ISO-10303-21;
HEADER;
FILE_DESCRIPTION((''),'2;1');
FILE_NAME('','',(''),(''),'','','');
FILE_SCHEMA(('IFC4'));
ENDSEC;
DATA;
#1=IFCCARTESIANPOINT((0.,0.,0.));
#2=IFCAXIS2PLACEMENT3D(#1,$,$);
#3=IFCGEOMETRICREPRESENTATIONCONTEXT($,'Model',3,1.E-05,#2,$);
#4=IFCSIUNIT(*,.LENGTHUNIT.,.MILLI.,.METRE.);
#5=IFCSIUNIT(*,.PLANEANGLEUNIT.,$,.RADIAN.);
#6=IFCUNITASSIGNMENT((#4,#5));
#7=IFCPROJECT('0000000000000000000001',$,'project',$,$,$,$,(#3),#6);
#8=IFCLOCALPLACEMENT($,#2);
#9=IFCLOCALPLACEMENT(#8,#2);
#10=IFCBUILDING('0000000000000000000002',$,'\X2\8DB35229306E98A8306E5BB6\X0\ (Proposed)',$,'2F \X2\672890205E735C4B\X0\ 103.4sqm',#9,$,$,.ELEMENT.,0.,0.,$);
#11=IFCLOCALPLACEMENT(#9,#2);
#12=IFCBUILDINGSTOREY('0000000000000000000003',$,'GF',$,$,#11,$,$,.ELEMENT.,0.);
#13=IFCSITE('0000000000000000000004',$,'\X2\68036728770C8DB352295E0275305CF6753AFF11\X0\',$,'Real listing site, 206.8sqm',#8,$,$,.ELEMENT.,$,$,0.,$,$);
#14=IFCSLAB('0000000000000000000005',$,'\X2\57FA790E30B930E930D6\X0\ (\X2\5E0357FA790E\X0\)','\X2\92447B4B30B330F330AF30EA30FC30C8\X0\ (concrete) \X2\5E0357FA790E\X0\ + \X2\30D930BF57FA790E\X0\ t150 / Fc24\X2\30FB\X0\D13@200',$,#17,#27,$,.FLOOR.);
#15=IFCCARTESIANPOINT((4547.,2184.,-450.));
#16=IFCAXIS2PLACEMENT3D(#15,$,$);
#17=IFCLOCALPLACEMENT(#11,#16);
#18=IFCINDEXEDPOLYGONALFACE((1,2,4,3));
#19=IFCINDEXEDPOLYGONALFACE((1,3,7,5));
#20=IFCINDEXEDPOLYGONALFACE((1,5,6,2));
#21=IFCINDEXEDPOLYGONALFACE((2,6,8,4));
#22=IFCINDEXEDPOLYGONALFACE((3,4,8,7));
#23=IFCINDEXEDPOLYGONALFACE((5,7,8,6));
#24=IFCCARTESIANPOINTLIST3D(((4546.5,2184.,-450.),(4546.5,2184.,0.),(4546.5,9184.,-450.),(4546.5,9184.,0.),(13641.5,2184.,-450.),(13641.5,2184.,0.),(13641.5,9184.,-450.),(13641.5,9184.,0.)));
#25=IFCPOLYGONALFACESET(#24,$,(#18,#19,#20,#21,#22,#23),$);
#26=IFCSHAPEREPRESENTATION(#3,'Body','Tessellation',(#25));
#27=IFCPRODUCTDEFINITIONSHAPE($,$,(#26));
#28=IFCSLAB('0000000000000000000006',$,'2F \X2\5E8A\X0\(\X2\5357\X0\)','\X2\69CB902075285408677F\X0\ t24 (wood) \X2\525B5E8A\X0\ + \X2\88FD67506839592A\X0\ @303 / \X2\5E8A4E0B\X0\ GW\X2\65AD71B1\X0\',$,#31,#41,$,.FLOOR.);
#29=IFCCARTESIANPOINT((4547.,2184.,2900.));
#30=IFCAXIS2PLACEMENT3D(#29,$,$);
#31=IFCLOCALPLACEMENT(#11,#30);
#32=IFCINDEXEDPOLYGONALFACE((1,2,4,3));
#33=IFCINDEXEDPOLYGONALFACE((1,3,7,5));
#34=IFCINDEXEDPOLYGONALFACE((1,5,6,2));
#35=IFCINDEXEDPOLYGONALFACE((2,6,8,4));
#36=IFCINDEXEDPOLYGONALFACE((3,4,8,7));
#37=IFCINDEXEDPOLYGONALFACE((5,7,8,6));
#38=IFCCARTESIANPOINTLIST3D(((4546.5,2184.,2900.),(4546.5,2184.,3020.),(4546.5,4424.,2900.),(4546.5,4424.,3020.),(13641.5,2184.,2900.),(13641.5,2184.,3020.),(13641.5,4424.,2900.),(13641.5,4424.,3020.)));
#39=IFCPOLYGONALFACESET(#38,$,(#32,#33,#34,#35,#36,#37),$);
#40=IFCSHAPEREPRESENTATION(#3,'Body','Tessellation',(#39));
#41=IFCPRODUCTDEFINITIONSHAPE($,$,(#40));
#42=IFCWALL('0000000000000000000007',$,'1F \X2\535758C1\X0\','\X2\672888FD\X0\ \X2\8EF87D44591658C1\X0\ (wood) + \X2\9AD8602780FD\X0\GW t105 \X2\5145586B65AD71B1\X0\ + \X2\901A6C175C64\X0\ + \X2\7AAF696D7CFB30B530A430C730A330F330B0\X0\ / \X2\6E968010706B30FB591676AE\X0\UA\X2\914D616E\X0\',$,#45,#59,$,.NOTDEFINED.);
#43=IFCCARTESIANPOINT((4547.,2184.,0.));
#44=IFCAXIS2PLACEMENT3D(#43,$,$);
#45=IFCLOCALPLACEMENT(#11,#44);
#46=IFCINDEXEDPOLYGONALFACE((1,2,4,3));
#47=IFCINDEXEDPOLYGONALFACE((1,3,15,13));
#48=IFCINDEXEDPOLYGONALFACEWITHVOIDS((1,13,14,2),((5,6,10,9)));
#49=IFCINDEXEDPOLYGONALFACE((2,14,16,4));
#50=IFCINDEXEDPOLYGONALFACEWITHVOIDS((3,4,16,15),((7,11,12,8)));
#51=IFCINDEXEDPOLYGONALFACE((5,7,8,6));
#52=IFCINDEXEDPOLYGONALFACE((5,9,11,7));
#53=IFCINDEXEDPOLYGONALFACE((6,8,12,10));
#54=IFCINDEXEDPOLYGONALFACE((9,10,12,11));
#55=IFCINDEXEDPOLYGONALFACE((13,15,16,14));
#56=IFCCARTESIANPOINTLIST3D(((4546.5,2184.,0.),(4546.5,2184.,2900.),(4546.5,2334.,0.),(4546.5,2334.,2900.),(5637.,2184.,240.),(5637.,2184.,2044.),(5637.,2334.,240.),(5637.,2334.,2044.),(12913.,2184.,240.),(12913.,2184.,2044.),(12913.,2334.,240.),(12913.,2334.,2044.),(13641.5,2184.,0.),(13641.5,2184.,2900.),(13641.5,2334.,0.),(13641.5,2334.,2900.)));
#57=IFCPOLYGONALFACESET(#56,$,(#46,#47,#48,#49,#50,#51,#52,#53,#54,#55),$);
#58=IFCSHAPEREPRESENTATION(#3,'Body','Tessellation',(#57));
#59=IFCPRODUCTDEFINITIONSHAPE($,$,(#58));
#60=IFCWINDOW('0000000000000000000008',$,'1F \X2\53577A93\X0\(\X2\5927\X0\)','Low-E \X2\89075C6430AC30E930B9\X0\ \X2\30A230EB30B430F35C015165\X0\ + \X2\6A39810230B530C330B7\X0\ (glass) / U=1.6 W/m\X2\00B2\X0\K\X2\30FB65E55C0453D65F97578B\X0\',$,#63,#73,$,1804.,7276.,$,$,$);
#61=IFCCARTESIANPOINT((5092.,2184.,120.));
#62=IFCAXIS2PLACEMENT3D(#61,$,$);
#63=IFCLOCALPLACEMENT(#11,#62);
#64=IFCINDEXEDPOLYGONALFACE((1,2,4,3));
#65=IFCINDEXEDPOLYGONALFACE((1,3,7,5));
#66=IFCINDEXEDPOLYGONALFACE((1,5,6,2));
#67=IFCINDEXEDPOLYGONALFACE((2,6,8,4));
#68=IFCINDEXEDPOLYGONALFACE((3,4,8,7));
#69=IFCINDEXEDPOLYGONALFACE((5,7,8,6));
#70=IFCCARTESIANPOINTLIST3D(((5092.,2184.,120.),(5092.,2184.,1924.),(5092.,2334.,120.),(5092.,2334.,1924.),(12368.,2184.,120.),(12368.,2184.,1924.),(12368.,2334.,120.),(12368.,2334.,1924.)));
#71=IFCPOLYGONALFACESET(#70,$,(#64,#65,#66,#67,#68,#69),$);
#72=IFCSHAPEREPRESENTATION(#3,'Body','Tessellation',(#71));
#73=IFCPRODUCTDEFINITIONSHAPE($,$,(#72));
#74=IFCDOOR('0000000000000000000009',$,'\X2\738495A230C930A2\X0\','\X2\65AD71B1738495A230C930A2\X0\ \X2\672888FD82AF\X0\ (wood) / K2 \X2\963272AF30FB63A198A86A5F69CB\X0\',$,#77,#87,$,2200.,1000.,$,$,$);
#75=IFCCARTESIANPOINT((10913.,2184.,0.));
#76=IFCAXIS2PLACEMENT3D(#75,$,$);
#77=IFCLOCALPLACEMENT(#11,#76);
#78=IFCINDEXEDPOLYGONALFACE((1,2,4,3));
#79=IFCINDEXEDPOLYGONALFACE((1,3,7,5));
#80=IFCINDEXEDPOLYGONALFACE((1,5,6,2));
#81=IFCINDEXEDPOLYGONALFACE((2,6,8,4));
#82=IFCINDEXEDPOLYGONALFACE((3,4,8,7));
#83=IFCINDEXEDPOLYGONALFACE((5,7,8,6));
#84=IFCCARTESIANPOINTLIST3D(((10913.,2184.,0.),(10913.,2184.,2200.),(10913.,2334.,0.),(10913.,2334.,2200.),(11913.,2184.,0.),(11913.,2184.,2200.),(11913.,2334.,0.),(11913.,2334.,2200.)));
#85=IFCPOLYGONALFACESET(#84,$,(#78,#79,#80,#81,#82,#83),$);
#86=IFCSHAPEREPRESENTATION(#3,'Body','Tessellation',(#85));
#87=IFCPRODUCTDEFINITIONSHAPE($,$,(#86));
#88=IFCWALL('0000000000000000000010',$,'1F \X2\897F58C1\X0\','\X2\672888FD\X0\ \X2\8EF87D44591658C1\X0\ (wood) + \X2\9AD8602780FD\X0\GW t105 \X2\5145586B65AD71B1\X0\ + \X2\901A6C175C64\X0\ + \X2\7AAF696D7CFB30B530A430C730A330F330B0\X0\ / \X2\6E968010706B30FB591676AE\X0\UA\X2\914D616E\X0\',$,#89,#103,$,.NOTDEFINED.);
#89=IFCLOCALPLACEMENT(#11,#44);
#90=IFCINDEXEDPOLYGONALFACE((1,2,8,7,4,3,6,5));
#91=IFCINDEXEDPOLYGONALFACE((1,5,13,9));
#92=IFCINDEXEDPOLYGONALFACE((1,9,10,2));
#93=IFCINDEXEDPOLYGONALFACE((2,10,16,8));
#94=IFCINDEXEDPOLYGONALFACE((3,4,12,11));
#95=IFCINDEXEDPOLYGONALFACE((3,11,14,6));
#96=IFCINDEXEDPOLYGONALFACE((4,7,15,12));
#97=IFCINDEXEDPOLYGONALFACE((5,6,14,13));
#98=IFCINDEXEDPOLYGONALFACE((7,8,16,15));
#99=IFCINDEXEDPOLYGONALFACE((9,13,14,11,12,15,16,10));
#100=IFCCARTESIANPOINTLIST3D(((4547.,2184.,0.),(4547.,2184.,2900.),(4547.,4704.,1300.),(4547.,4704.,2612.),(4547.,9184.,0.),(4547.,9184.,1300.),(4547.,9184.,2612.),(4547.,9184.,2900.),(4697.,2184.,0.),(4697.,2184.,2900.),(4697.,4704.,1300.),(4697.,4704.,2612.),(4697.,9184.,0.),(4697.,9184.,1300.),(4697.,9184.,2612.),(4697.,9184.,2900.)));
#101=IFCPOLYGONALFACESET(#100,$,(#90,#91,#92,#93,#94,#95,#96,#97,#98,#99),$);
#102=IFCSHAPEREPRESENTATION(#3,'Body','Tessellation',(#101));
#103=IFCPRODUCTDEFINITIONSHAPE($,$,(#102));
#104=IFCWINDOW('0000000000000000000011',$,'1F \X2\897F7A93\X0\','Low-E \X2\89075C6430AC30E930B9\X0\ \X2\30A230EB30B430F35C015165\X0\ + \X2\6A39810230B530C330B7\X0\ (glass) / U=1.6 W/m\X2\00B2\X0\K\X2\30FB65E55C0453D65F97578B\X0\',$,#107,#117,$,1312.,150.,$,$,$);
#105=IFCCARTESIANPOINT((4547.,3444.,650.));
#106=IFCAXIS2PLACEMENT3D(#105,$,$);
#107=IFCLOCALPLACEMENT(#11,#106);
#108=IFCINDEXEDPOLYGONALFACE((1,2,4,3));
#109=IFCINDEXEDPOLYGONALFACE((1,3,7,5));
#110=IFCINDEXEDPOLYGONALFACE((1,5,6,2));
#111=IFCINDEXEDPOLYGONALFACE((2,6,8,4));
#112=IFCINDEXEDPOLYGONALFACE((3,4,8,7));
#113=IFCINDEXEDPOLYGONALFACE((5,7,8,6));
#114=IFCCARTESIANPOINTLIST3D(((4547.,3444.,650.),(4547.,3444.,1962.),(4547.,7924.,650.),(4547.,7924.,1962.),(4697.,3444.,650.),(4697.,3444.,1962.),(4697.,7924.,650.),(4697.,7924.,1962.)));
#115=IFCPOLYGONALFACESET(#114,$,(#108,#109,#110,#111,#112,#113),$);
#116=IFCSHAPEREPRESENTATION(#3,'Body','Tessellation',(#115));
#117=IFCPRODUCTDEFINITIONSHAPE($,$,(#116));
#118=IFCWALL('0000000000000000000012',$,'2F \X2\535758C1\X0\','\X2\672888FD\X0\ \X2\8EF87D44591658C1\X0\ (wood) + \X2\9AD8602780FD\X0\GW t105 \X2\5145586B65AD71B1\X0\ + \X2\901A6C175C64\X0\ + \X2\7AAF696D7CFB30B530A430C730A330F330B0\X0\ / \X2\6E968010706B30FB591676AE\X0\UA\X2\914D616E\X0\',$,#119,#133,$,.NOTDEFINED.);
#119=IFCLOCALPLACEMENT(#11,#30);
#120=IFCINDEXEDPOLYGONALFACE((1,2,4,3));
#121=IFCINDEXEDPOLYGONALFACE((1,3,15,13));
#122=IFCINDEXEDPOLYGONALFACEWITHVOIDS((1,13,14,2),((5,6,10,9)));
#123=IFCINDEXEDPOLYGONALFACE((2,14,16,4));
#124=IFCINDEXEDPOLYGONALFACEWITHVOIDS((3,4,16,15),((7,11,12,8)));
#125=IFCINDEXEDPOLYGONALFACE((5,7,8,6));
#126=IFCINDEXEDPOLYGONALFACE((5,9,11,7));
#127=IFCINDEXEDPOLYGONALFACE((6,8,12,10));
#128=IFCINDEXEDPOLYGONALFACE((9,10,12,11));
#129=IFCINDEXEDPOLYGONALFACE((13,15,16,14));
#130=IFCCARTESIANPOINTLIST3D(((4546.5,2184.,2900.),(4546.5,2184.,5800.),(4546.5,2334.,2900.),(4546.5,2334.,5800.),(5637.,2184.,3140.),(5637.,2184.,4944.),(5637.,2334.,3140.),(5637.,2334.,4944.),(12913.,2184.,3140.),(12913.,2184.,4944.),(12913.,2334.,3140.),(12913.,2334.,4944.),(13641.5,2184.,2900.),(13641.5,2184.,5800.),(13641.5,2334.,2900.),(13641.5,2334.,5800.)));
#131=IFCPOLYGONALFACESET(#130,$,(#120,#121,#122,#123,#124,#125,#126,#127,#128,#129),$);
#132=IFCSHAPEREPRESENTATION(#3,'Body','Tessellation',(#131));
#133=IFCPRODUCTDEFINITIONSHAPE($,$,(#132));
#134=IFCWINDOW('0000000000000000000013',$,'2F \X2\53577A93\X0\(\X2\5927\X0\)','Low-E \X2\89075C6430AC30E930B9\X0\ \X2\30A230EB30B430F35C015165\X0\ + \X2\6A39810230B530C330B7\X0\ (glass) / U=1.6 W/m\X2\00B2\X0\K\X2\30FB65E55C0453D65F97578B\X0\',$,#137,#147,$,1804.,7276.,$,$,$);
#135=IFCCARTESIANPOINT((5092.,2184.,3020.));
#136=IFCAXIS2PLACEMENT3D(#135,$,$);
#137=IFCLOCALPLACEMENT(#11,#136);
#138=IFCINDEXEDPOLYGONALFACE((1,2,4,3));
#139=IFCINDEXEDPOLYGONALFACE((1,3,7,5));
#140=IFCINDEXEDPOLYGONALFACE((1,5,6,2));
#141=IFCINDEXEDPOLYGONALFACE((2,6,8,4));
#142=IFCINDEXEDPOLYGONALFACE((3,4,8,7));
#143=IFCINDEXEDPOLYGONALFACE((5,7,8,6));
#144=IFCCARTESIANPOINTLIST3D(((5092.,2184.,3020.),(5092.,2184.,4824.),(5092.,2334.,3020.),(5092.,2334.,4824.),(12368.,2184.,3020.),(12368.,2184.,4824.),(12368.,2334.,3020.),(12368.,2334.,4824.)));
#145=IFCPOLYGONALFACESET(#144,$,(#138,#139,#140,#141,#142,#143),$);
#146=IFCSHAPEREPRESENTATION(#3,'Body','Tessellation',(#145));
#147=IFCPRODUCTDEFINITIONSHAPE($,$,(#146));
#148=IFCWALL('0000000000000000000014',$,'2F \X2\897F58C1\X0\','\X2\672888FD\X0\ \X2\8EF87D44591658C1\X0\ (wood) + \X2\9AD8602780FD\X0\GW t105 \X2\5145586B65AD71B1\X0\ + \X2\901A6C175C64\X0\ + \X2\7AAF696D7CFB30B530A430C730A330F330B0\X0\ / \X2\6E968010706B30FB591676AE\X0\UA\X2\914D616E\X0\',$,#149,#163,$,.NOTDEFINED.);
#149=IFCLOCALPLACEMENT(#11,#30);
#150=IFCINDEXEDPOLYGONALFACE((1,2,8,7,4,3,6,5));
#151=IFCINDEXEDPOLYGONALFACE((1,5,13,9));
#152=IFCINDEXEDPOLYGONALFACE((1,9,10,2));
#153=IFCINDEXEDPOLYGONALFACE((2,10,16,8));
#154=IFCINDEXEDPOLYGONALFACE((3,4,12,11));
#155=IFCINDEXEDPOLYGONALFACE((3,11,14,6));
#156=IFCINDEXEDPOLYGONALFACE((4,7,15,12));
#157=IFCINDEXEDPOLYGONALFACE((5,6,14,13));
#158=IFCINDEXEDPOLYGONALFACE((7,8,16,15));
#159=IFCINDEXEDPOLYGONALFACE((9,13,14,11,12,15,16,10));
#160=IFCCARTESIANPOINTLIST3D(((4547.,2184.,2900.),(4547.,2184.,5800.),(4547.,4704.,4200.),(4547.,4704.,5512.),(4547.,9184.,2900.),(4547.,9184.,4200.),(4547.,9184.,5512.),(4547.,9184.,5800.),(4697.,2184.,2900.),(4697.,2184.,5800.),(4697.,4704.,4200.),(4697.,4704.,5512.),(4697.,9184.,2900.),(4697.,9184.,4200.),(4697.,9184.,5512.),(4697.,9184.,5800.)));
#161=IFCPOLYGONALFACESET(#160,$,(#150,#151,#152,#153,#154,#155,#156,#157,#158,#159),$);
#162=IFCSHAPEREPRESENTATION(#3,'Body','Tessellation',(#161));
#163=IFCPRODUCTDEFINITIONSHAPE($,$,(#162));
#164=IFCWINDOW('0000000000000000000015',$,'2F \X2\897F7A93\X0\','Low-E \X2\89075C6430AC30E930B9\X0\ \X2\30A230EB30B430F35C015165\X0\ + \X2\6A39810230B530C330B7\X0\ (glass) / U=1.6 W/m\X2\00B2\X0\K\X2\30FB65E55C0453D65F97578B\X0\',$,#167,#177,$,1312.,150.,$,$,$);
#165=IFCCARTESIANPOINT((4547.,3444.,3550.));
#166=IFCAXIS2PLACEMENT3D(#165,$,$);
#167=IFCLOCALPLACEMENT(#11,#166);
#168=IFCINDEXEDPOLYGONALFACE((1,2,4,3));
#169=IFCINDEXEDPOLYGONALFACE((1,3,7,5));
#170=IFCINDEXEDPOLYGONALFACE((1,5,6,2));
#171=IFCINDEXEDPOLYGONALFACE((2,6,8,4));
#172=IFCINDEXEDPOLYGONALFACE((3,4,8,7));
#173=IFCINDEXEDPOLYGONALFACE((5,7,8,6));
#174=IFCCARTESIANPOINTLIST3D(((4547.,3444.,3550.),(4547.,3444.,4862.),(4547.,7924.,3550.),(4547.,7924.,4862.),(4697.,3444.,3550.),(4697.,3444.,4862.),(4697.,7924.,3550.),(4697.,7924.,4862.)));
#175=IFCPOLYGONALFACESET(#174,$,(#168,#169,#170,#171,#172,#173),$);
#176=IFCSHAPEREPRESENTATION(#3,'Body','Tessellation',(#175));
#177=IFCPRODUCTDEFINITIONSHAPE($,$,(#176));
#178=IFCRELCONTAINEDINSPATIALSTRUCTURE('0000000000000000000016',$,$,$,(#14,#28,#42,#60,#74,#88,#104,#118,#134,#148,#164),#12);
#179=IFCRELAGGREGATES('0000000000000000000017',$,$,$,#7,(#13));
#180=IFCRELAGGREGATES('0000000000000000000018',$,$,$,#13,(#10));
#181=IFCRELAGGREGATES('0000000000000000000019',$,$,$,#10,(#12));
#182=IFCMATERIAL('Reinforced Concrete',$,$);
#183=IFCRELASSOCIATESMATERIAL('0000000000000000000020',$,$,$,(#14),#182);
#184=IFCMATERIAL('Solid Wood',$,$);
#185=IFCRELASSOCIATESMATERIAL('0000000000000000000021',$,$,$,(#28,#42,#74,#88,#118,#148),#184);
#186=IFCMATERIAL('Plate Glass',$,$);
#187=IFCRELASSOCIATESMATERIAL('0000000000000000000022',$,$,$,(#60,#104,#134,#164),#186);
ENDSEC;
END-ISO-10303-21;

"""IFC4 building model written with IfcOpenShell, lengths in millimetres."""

from ifc_helpers import new_model, si_unit, frame, frame_2d, origin, place, context, project, spatial, rectangle, extrude, material, element, fill, save


model = new_model("IFC4")

# Units and contexts
model_context = context("Model", 3, precision=1e-05, world=origin())
ifc_project = project(units=[si_unit("LENGTHUNIT", "METRE", prefix="MILLI"), si_unit("PLANEANGLEUNIT", "RADIAN")], contexts=[model_context])

# Site, building, storey
site_placement = place(None, origin())
site = spatial("IfcSite", under=ifc_project, at=site_placement, Name="栃木県足利市田島町１", ObjectType="Real listing site, 206.8sqm", CompositionType="ELEMENT", RefElevation=0.0)
building_placement = place(site_placement, origin())
building = spatial("IfcBuilding", under=site, at=building_placement, Name="足利の風の家 (Proposed)", ObjectType="2F 木造平屋 103.4sqm", CompositionType="ELEMENT", ElevationOfRefHeight=0.0, ElevationOfTerrain=0.0)
storey_placement = place(building_placement, origin())
storey = spatial("IfcBuildingStorey", under=building, at=storey_placement, Name="GF", CompositionType="ELEMENT", Elevation=0.0)

# Slabs
ifc_material_1 = material(Name="Reinforced Concrete")
slab_1_placement = place(storey_placement, frame((4547.0, 2184.0, -450.0)))
element("IfcSlab", 1, at=slab_1_placement, inside=storey, material=ifc_material_1, Name="基礎スラブ (布基礎)", Description="鉄筋コンクリート (concrete) 布基礎 + ベタ基礎 t150 / Fc24・D13@200", PredefinedType="FLOOR", context=model_context, shape_type="SweptSolid", body=[
    extrude(rectangle(XDim=9095.0, YDim=7000.0, at=frame_2d((4547.0, 3500.0))), frame((4547.0, 2184.0, -450.0)), (0.0, 0.0, 1.0), 450.0),
])
ifc_material_2 = material(Name="Solid Wood")
slab_2_placement = place(storey_placement, frame((4547.0, 2184.0, 2900.0)))
element("IfcSlab", 2, at=slab_2_placement, inside=storey, material=ifc_material_2, Name="2F 床(南)", Description="構造用合板 t24 (wood) 剛床 + 製材根太 @303 / 床下 GW断熱", PredefinedType="FLOOR", context=model_context, shape_type="SweptSolid", body=[
    extrude(rectangle(XDim=9095.0, YDim=2240.0, at=frame_2d((4547.0, 1120.0))), frame((4547.0, 2184.0, 2900.0)), (0.0, 0.0, 1.0), 120.0),
])

# Wall, openings, window, door
wall_1_placement = place(storey_placement, frame((4547.0, 2184.0, 0.0)))
wall_1 = element("IfcWall", 3, at=wall_1_placement, inside=storey, material=ifc_material_2, Name="1F 南壁", Description="木製 軸組外壁 (wood) + 高性能GW t105 充填断熱 + 通気層 + 窯業系サイディング / 準耐火・外皮UA配慮", PredefinedType="NOTDEFINED", context=model_context, shape_type="SweptSolid", body=[
    extrude(rectangle(XDim=9095.0, YDim=150.0, at=frame_2d((4547.0, 75.0))), frame((4547.0, 2184.0, 0.0)), (0.0, 0.0, 1.0), 2900.0),
])
opening_1_placement = place(storey_placement, frame((5092.0, 2184.0, 120.0)))
opening_1 = element("IfcOpeningElement", 4, at=opening_1_placement, cuts=wall_1, PredefinedType="NOTDEFINED", context=model_context, shape_type="SweptSolid", body=[
    extrude(rectangle(XDim=7276.0, YDim=150.0, at=frame_2d((3638.0, 75.0))), frame((5092.0, 2184.0, 120.0)), (0.0, 0.0, 1.0), 1804.0),
])
opening_2_placement = place(storey_placement, frame((10913.0, 2184.0, 0.0)))
opening_2 = element("IfcOpeningElement", 5, at=opening_2_placement, cuts=wall_1, PredefinedType="NOTDEFINED", context=model_context, shape_type="SweptSolid", body=[
    extrude(rectangle(XDim=1000.0, YDim=150.0, at=frame_2d((500.0, 75.0))), frame((10913.0, 2184.0, 0.0)), (0.0, 0.0, 1.0), 2200.0),
])
ifc_material_3 = material(Name="Plate Glass")
window_1_placement = place(storey_placement, frame((5092.0, 2184.0, 120.0)))
window_1 = element("IfcWindow", 6, at=window_1_placement, inside=storey, material=ifc_material_3, Name="1F 南窓(大)", Description="Low-E 複層ガラス アルゴン封入 + 樹脂サッシ (glass) / U=1.6 W/m²K・日射取得型", OverallHeight=1804.0, OverallWidth=7276.0, context=model_context, shape_type="SweptSolid", body=[
    extrude(rectangle(XDim=7276.0, YDim=150.0, at=frame_2d((3638.0, 75.0))), frame((5092.0, 2184.0, 120.0)), (0.0, 0.0, 1.0), 1804.0),
])
fill(opening_1, window_1)
door_placement = place(storey_placement, frame((10913.0, 2184.0, 0.0)))
door = element("IfcDoor", 7, at=door_placement, inside=storey, material=ifc_material_2, Name="玄関ドア", Description="断熱玄関ドア 木製芯 (wood) / K2 防犯・採風機構", OverallHeight=2200.0, OverallWidth=1000.0, context=model_context, shape_type="SweptSolid", body=[
    extrude(rectangle(XDim=1000.0, YDim=150.0, at=frame_2d((500.0, 75.0))), frame((10913.0, 2184.0, 0.0)), (0.0, 0.0, 1.0), 2200.0),
])
fill(opening_2, door)

# Walls, openings, windows
wall_2_placement = place(storey_placement, frame((4547.0, 2184.0, 0.0)))
wall_2 = element("IfcWall", 8, at=wall_2_placement, inside=storey, material=ifc_material_2, Name="1F 西壁", Description="木製 軸組外壁 (wood) + 高性能GW t105 充填断熱 + 通気層 + 窯業系サイディング / 準耐火・外皮UA配慮", PredefinedType="NOTDEFINED", context=model_context, shape_type="SweptSolid", body=[
    extrude(rectangle(XDim=150.0, YDim=7000.0, at=frame_2d((75.0, 3500.0))), frame((4547.0, 2184.0, 0.0)), (0.0, 0.0, 1.0), 2900.0),
])
opening_3_placement = place(storey_placement, frame((4547.0, 3444.0, 650.0)))
opening_3 = element("IfcOpeningElement", 9, at=opening_3_placement, cuts=wall_2, PredefinedType="NOTDEFINED", context=model_context, shape_type="SweptSolid", body=[
    extrude(rectangle(XDim=150.0, YDim=4480.0, at=frame_2d((75.0, 2240.0))), frame((4547.0, 3444.0, 650.0)), (0.0, 0.0, 1.0), 1312.0),
])
window_2_placement = place(storey_placement, frame((4547.0, 3444.0, 650.0)))
window_2 = element("IfcWindow", 10, at=window_2_placement, inside=storey, material=ifc_material_3, Name="1F 西窓", Description="Low-E 複層ガラス アルゴン封入 + 樹脂サッシ (glass) / U=1.6 W/m²K・日射取得型", OverallHeight=1312.0, OverallWidth=150.0, context=model_context, shape_type="SweptSolid", body=[
    extrude(rectangle(XDim=150.0, YDim=4480.0, at=frame_2d((75.0, 2240.0))), frame((4547.0, 3444.0, 650.0)), (0.0, 0.0, 1.0), 1312.0),
])
fill(opening_3, window_2)
wall_3_placement = place(storey_placement, frame((4547.0, 2184.0, 2900.0)))
wall_3 = element("IfcWall", 11, at=wall_3_placement, inside=storey, material=ifc_material_2, Name="2F 南壁", Description="木製 軸組外壁 (wood) + 高性能GW t105 充填断熱 + 通気層 + 窯業系サイディング / 準耐火・外皮UA配慮", PredefinedType="NOTDEFINED", context=model_context, shape_type="SweptSolid", body=[
    extrude(rectangle(XDim=9095.0, YDim=150.0, at=frame_2d((4547.0, 75.0))), frame((4547.0, 2184.0, 2900.0)), (0.0, 0.0, 1.0), 2900.0),
])
opening_4_placement = place(storey_placement, frame((5092.0, 2184.0, 3020.0)))
opening_4 = element("IfcOpeningElement", 12, at=opening_4_placement, cuts=wall_3, PredefinedType="NOTDEFINED", context=model_context, shape_type="SweptSolid", body=[
    extrude(rectangle(XDim=7276.0, YDim=150.0, at=frame_2d((3638.0, 75.0))), frame((5092.0, 2184.0, 3020.0)), (0.0, 0.0, 1.0), 1804.0),
])
window_3_placement = place(storey_placement, frame((5092.0, 2184.0, 3020.0)))
window_3 = element("IfcWindow", 13, at=window_3_placement, inside=storey, material=ifc_material_3, Name="2F 南窓(大)", Description="Low-E 複層ガラス アルゴン封入 + 樹脂サッシ (glass) / U=1.6 W/m²K・日射取得型", OverallHeight=1804.0, OverallWidth=7276.0, context=model_context, shape_type="SweptSolid", body=[
    extrude(rectangle(XDim=7276.0, YDim=150.0, at=frame_2d((3638.0, 75.0))), frame((5092.0, 2184.0, 3020.0)), (0.0, 0.0, 1.0), 1804.0),
])
fill(opening_4, window_3)
wall_4_placement = place(storey_placement, frame((4547.0, 2184.0, 2900.0)))
wall_4 = element("IfcWall", 14, at=wall_4_placement, inside=storey, material=ifc_material_2, Name="2F 西壁", Description="木製 軸組外壁 (wood) + 高性能GW t105 充填断熱 + 通気層 + 窯業系サイディング / 準耐火・外皮UA配慮", PredefinedType="NOTDEFINED", context=model_context, shape_type="SweptSolid", body=[
    extrude(rectangle(XDim=150.0, YDim=7000.0, at=frame_2d((75.0, 3500.0))), frame((4547.0, 2184.0, 2900.0)), (0.0, 0.0, 1.0), 2900.0),
])
opening_5_placement = place(storey_placement, frame((4547.0, 3444.0, 3550.0)))
opening_5 = element("IfcOpeningElement", 15, at=opening_5_placement, cuts=wall_4, PredefinedType="NOTDEFINED", context=model_context, shape_type="SweptSolid", body=[
    extrude(rectangle(XDim=150.0, YDim=4480.0, at=frame_2d((75.0, 2240.0))), frame((4547.0, 3444.0, 3550.0)), (0.0, 0.0, 1.0), 1312.0),
])
window_4_placement = place(storey_placement, frame((4547.0, 3444.0, 3550.0)))
window_4 = element("IfcWindow", 16, at=window_4_placement, inside=storey, material=ifc_material_3, Name="2F 西窓", Description="Low-E 複層ガラス アルゴン封入 + 樹脂サッシ (glass) / U=1.6 W/m²K・日射取得型", OverallHeight=1312.0, OverallWidth=150.0, context=model_context, shape_type="SweptSolid", body=[
    extrude(rectangle(XDim=150.0, YDim=4480.0, at=frame_2d((75.0, 2240.0))), frame((4547.0, 3444.0, 3550.0)), (0.0, 0.0, 1.0), 1312.0),
])
fill(opening_5, window_4)

save(model, "model.ifc")
